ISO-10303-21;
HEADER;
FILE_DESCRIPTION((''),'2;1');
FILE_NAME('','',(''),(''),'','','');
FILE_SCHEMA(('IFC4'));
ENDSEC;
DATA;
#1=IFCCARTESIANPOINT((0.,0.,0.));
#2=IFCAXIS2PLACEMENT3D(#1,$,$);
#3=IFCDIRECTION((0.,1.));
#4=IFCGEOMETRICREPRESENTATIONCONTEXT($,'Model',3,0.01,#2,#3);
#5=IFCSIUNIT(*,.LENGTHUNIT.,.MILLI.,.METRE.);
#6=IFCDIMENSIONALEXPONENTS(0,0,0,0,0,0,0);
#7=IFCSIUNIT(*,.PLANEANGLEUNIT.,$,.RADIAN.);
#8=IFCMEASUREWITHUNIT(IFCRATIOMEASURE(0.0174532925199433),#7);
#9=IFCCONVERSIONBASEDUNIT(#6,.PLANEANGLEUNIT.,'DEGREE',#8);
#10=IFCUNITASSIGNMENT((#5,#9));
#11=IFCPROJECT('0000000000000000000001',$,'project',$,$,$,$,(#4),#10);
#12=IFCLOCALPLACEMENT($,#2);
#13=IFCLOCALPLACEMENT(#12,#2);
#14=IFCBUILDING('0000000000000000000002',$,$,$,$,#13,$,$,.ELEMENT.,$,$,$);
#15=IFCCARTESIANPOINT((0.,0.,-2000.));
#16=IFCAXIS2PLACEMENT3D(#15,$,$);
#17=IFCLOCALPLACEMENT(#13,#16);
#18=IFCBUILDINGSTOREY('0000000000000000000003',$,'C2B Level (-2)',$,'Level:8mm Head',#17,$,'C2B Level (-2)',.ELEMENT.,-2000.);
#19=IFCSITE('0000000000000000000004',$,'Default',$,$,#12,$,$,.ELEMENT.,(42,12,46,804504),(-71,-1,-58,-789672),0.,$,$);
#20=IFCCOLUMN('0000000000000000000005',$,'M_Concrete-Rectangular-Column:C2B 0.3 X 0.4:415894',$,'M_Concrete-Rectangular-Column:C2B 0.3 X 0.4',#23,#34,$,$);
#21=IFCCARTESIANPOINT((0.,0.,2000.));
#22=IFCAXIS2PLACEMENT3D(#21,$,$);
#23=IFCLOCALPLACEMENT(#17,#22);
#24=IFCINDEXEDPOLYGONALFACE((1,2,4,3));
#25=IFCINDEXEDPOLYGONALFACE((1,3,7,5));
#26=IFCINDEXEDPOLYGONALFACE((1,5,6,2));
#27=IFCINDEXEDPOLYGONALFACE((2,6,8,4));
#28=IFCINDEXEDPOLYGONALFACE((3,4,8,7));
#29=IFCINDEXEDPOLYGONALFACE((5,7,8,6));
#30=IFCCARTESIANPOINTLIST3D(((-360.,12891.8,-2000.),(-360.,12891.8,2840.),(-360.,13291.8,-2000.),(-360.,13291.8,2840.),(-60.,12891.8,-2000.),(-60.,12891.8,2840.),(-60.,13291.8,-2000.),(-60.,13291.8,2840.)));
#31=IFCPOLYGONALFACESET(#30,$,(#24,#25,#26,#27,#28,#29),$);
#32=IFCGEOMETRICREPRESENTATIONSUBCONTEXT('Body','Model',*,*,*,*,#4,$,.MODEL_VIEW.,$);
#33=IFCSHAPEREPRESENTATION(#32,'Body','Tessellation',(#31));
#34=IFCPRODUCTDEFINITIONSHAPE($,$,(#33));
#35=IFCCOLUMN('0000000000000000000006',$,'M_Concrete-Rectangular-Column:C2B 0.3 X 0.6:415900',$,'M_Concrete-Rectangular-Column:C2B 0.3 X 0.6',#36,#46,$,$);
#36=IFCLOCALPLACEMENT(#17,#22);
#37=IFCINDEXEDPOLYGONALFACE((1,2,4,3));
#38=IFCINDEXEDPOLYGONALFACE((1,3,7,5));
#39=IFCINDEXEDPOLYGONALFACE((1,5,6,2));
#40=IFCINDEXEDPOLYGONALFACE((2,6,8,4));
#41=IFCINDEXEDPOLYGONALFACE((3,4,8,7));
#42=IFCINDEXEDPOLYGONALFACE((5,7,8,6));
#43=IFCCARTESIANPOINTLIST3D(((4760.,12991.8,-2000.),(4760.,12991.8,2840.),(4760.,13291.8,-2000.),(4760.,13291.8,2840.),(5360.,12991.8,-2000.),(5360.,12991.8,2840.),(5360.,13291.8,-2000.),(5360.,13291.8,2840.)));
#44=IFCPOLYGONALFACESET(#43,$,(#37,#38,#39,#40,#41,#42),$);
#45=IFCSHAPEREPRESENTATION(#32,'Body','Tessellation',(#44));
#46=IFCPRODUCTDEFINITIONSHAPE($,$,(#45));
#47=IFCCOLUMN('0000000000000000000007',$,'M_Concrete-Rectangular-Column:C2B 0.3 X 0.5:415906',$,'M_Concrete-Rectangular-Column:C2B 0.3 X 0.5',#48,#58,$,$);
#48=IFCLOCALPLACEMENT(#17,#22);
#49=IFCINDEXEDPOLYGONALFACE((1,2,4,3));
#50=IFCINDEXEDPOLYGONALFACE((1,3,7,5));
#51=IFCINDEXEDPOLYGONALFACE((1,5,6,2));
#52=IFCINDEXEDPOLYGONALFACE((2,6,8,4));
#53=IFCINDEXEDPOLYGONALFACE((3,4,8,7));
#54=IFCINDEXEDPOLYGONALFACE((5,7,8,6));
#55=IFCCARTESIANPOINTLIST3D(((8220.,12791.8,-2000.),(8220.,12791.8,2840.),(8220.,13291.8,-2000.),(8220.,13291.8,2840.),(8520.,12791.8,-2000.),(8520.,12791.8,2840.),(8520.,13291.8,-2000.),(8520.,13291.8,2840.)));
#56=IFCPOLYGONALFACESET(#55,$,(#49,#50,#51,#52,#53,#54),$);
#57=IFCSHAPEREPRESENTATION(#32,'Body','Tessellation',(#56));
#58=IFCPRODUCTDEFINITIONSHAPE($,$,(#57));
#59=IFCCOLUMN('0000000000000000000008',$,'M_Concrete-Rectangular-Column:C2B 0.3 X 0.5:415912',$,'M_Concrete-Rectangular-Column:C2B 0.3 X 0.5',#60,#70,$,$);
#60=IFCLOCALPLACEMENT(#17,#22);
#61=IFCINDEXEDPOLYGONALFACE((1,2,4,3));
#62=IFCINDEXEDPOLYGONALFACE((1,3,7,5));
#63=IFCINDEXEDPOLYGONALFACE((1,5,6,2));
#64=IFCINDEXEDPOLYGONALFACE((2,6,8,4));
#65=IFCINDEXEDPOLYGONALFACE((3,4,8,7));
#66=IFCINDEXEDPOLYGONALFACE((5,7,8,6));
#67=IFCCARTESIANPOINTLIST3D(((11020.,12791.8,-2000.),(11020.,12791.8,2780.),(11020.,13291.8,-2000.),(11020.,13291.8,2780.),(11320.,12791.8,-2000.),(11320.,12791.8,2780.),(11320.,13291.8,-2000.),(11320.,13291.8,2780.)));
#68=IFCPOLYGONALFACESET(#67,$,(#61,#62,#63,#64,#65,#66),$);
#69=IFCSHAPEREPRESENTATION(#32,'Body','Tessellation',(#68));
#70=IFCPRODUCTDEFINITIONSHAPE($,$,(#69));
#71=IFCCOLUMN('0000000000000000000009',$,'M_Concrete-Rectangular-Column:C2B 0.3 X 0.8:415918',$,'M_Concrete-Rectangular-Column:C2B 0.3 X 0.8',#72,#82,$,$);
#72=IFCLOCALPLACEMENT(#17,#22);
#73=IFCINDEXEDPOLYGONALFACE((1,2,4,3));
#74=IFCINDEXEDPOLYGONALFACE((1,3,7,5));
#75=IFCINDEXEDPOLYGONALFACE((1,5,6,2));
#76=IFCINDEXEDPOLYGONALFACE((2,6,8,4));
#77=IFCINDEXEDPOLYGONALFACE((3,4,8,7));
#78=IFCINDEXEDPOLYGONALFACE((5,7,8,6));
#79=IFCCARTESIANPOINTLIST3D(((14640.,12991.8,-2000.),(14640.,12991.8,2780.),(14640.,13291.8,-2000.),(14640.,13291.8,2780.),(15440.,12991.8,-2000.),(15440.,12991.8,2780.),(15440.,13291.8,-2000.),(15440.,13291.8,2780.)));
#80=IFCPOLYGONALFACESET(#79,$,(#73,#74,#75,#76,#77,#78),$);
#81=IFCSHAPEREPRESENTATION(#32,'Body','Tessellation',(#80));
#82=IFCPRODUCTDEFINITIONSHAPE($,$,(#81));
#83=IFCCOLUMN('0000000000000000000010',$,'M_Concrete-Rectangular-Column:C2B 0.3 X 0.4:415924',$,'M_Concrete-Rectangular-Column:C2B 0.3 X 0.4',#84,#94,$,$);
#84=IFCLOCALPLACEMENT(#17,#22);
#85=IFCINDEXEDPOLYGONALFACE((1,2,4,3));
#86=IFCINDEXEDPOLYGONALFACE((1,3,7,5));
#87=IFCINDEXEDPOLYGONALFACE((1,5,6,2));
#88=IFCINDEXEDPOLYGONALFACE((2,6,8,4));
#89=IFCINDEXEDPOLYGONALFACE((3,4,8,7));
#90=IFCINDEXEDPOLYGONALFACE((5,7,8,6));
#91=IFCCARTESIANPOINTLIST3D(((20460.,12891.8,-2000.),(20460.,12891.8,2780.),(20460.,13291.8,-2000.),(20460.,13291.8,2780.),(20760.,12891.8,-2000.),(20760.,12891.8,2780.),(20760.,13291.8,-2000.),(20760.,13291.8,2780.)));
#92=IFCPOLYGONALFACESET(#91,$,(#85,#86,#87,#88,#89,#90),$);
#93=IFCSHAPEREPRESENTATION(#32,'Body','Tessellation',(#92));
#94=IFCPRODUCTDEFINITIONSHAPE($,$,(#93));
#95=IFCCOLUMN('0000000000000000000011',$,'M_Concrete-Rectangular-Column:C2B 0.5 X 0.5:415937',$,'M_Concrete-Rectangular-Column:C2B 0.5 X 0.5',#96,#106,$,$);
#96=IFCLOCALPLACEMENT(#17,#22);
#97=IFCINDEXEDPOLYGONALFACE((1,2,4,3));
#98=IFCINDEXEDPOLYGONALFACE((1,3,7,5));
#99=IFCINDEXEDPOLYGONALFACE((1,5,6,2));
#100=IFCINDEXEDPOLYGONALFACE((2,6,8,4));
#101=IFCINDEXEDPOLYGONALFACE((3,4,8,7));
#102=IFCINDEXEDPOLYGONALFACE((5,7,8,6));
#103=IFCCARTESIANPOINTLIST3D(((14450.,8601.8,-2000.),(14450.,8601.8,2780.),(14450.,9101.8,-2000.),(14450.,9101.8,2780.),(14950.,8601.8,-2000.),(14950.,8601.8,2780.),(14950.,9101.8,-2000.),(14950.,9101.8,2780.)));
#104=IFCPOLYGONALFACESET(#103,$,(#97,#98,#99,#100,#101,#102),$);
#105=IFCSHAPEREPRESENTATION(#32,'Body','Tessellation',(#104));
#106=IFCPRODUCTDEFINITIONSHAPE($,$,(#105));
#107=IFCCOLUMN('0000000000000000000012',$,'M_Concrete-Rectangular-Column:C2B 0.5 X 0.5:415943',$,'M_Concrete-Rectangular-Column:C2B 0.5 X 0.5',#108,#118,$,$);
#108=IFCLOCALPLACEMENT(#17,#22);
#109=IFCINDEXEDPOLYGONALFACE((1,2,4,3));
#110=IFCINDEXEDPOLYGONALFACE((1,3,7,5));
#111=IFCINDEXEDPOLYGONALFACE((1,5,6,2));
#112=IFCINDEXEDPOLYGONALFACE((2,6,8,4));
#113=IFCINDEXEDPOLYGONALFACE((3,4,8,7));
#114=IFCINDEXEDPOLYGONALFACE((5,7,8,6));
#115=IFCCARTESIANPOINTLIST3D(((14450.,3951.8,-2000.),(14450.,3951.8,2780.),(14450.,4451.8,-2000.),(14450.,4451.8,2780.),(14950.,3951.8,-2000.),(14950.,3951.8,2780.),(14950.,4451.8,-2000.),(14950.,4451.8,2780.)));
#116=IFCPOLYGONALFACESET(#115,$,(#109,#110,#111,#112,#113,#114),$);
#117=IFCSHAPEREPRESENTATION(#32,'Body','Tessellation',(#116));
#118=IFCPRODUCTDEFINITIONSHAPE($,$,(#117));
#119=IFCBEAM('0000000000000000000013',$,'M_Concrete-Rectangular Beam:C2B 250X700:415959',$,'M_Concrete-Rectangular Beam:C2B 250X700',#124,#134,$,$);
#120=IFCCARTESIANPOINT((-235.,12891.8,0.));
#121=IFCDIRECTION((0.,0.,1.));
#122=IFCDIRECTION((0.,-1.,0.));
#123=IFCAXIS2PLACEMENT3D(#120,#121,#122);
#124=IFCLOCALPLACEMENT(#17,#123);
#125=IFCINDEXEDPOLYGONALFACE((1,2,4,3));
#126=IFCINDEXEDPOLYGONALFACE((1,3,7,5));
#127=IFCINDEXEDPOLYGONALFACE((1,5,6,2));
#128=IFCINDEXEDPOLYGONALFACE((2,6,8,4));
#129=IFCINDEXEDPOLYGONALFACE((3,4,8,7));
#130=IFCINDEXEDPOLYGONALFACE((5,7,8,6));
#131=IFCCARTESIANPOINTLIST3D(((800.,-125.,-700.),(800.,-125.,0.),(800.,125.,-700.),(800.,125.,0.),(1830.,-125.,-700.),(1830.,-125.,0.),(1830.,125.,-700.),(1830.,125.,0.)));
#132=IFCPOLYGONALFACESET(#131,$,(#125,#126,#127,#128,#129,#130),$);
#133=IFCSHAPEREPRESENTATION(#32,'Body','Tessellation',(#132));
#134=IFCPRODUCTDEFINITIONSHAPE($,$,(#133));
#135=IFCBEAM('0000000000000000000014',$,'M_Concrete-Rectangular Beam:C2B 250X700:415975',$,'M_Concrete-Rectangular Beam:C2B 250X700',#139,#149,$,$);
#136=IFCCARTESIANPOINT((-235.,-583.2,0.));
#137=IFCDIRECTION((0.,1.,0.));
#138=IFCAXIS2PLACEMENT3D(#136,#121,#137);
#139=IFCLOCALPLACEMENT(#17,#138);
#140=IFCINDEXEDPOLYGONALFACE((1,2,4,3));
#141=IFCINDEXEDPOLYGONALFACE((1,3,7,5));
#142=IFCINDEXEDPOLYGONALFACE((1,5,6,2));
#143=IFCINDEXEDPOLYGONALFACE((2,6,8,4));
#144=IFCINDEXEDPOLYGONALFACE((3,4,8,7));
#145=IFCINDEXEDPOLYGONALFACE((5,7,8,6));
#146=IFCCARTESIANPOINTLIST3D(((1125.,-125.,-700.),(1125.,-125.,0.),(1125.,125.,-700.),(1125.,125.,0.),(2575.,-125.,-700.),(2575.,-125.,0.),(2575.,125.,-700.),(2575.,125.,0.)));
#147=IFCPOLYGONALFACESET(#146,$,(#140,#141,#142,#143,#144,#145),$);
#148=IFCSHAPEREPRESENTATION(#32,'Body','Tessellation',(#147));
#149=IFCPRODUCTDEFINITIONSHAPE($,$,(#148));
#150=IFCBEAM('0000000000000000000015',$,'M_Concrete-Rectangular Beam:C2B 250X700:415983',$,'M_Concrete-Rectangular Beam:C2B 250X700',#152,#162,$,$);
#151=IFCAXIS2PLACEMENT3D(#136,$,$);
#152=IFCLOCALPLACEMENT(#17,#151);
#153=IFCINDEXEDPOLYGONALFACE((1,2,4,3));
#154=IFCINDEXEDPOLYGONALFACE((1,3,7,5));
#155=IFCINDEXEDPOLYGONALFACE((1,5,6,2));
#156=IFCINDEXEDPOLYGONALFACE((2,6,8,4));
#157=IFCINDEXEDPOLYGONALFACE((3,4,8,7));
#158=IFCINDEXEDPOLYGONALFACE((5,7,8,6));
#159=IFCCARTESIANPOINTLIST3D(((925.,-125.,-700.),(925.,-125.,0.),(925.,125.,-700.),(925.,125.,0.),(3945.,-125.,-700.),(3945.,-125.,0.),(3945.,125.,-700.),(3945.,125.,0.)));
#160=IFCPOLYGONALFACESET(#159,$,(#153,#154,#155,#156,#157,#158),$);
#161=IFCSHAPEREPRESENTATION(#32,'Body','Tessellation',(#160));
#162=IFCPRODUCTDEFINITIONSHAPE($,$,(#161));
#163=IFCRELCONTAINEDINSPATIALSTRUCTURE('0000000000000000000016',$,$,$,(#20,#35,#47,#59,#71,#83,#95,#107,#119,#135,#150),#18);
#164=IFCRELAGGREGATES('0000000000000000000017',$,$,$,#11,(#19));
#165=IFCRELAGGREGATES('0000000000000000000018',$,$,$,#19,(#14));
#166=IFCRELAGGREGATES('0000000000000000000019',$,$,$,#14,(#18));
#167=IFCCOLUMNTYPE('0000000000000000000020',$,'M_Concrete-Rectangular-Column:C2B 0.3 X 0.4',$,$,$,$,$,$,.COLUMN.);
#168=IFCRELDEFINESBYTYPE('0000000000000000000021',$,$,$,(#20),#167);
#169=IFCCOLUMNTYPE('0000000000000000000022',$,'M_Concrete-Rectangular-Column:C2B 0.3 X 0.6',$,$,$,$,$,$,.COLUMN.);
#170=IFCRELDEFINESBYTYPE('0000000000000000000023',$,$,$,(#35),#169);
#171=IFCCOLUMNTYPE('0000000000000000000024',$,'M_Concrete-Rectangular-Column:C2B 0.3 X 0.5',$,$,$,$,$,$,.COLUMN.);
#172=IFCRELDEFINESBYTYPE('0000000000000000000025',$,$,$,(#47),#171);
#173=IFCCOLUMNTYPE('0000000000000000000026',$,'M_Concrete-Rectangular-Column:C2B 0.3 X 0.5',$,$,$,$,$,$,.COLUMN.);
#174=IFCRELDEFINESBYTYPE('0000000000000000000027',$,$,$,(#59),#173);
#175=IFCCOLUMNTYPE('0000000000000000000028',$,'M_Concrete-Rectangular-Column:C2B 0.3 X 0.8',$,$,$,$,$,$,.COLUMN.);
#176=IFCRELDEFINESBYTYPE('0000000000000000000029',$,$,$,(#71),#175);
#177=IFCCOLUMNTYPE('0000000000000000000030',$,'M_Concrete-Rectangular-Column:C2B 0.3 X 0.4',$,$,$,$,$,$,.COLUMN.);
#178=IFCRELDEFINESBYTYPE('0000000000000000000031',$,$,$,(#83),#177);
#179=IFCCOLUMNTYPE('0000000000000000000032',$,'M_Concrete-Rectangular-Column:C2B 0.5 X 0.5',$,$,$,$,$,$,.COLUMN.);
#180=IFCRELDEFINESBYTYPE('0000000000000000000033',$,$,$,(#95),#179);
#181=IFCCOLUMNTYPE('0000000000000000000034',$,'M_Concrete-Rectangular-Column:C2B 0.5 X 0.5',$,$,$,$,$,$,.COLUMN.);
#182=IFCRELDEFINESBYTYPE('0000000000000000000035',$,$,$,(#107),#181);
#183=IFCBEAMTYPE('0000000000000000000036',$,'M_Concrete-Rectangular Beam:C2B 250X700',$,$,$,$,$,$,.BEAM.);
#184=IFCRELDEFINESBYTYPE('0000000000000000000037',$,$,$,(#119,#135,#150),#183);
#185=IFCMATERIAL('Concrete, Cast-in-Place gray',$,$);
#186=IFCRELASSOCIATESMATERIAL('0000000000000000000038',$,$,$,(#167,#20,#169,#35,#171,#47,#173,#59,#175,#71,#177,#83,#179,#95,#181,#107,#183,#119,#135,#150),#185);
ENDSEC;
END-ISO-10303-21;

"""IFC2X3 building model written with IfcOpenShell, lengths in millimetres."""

from ifc_helpers import new_model, entity, si_unit, converted_unit, direction, frame, frame_2d, origin, origin_2d_with_axis, place, context, subcontext, project, spatial, rectangle, extrude, source, transform, mapped, material, type_object, type_shapes, element, save


model = new_model("IFC2X3")

# Units and contexts
model_context = context("Model", 3, precision=0.01, world=origin(), true_north=direction((0.0, 1.0)))
body_context = subcontext(model_context, "Body", "Model", "MODEL_VIEW")
ifc_project = project(units=[si_unit("LENGTHUNIT", "METRE", prefix="MILLI"), converted_unit("PLANEANGLEUNIT", "DEGREE", entity("IfcRatioMeasure", 0.0174532925199433), si_unit("PLANEANGLEUNIT", "RADIAN"), dimensions=[0, 0, 0, 0, 0, 0, 0])], contexts=[model_context])

# Site, building, storey
site_placement = place(None, origin())
site = spatial("IfcSite", under=ifc_project, at=site_placement, Name="Default", CompositionType="ELEMENT", RefLatitude=(42, 12, 46, 804504), RefLongitude=(-71, -1, -58, -789672), RefElevation=0.0)
building_placement = place(site_placement, origin())
building = spatial("IfcBuilding", under=site, at=building_placement, CompositionType="ELEMENT")
storey_placement = place(building_placement, frame((0.0, 0.0, -2000.0)))
storey = spatial("IfcBuildingStorey", under=building, at=storey_placement, Name="C2B Level (-2)", ObjectType="Level:8mm Head", LongName="C2B Level (-2)", CompositionType="ELEMENT", Elevation=-2000.0)

# Columns
ifc_material = material(Name="Concrete, Cast-in-Place gray")
column_type_1 = type_object("IfcColumnType", Name="M_Concrete-Rectangular-Column:C2B 0.3 X 0.4", PredefinedType="COLUMN", material=ifc_material)
shared_shape_1 = source(origin(), body_context, "Body", "SweptSolid", [
    extrude(rectangle(XDim=400.0, YDim=300.0, at=frame_2d((0.0, 0.0), x_axis=(1.0, 0.0))), frame((-210.0, 13091.8, -2000.0), z_axis=(0.0, 0.0, 1.0), x_axis=(0.0, -1.0, 0.0)), (0.0, 0.0, 1.0), 4840.0),
])
type_shapes(column_type_1, [shared_shape_1])
column_1_placement = place(storey_placement, frame((0.0, 0.0, 2000.0)))
element("IfcColumn", 1, at=column_1_placement, inside=storey, type_object=column_type_1, material=ifc_material, Name="M_Concrete-Rectangular-Column:C2B 0.3 X 0.4:415894", ObjectType="M_Concrete-Rectangular-Column:C2B 0.3 X 0.4", context=body_context, shape_type="MappedRepresentation", body=[
    mapped(shared_shape_1, transform((0.0, 0.0, 0.0), scale=1.0)),
])
column_type_2 = type_object("IfcColumnType", Name="M_Concrete-Rectangular-Column:C2B 0.3 X 0.6", PredefinedType="COLUMN", material=ifc_material)
shared_shape_2 = source(origin(), body_context, "Body", "SweptSolid", [
    extrude(rectangle(XDim=300.0, YDim=600.0, at=origin_2d_with_axis()), frame((5060.0, 13141.8, -2000.0), z_axis=(0.0, 0.0, 1.0), x_axis=(0.0, -1.0, 0.0)), (0.0, 0.0, 1.0), 4840.0),
])
type_shapes(column_type_2, [shared_shape_2])
column_2_placement = place(storey_placement, frame((0.0, 0.0, 2000.0)))
element("IfcColumn", 2, at=column_2_placement, inside=storey, type_object=column_type_2, material=ifc_material, Name="M_Concrete-Rectangular-Column:C2B 0.3 X 0.6:415900", ObjectType="M_Concrete-Rectangular-Column:C2B 0.3 X 0.6", context=body_context, shape_type="MappedRepresentation", body=[
    mapped(shared_shape_2, transform((0.0, 0.0, 0.0), scale=1.0)),
])
column_type_3 = type_object("IfcColumnType", Name="M_Concrete-Rectangular-Column:C2B 0.3 X 0.5", PredefinedType="COLUMN", material=ifc_material)
shared_shape_3 = source(origin(), body_context, "Body", "SweptSolid", [
    extrude(rectangle(XDim=500.0, YDim=300.0, at=frame_2d((0.0, 0.0), x_axis=(1.0, 0.0))), frame((8370.0, 13041.8, -2000.0), z_axis=(0.0, 0.0, 1.0), x_axis=(0.0, -1.0, 0.0)), (0.0, 0.0, 1.0), 4840.0),
])
type_shapes(column_type_3, [shared_shape_3])
column_3_placement = place(storey_placement, frame((0.0, 0.0, 2000.0)))
element("IfcColumn", 3, at=column_3_placement, inside=storey, type_object=column_type_3, material=ifc_material, Name="M_Concrete-Rectangular-Column:C2B 0.3 X 0.5:415906", ObjectType="M_Concrete-Rectangular-Column:C2B 0.3 X 0.5", context=body_context, shape_type="MappedRepresentation", body=[
    mapped(shared_shape_3, transform((0.0, 0.0, 0.0), scale=1.0)),
])
column_type_4 = type_object("IfcColumnType", Name="M_Concrete-Rectangular-Column:C2B 0.3 X 0.5", PredefinedType="COLUMN", material=ifc_material)
shared_shape_4 = source(origin(), body_context, "Body", "SweptSolid", [
    extrude(rectangle(XDim=500.0, YDim=300.0, at=origin_2d_with_axis()), frame((11170.0, 13041.8, -2000.0), z_axis=(0.0, 0.0, 1.0), x_axis=(0.0, -1.0, 0.0)), (0.0, 0.0, 1.0), 4780.0),
])
type_shapes(column_type_4, [shared_shape_4])
column_4_placement = place(storey_placement, frame((0.0, 0.0, 2000.0)))
element("IfcColumn", 4, at=column_4_placement, inside=storey, type_object=column_type_4, material=ifc_material, Name="M_Concrete-Rectangular-Column:C2B 0.3 X 0.5:415912", ObjectType="M_Concrete-Rectangular-Column:C2B 0.3 X 0.5", context=body_context, shape_type="MappedRepresentation", body=[
    mapped(shared_shape_4, transform((0.0, 0.0, 0.0), scale=1.0)),
])
column_type_5 = type_object("IfcColumnType", Name="M_Concrete-Rectangular-Column:C2B 0.3 X 0.8", PredefinedType="COLUMN", material=ifc_material)
shared_shape_5 = source(origin(), body_context, "Body", "SweptSolid", [
    extrude(rectangle(XDim=300.0, YDim=800.0, at=origin_2d_with_axis()), frame((15040.0, 13141.8, -2000.0), z_axis=(0.0, 0.0, 1.0), x_axis=(0.0, -1.0, 0.0)), (0.0, 0.0, 1.0), 4780.0),
])
type_shapes(column_type_5, [shared_shape_5])
column_5_placement = place(storey_placement, frame((0.0, 0.0, 2000.0)))
element("IfcColumn", 5, at=column_5_placement, inside=storey, type_object=column_type_5, material=ifc_material, Name="M_Concrete-Rectangular-Column:C2B 0.3 X 0.8:415918", ObjectType="M_Concrete-Rectangular-Column:C2B 0.3 X 0.8", context=body_context, shape_type="MappedRepresentation", body=[
    mapped(shared_shape_5, transform((0.0, 0.0, 0.0), scale=1.0)),
])
column_type_6 = type_object("IfcColumnType", Name="M_Concrete-Rectangular-Column:C2B 0.3 X 0.4", PredefinedType="COLUMN", material=ifc_material)
shared_shape_6 = source(origin(), body_context, "Body", "SweptSolid", [
    extrude(rectangle(XDim=400.0, YDim=300.0, at=origin_2d_with_axis()), frame((20610.0, 13091.8, -2000.0), z_axis=(0.0, 0.0, 1.0), x_axis=(0.0, -1.0, 0.0)), (0.0, 0.0, 1.0), 4780.0),
])
type_shapes(column_type_6, [shared_shape_6])
column_6_placement = place(storey_placement, frame((0.0, 0.0, 2000.0)))
element("IfcColumn", 6, at=column_6_placement, inside=storey, type_object=column_type_6, material=ifc_material, Name="M_Concrete-Rectangular-Column:C2B 0.3 X 0.4:415924", ObjectType="M_Concrete-Rectangular-Column:C2B 0.3 X 0.4", context=body_context, shape_type="MappedRepresentation", body=[
    mapped(shared_shape_6, transform((0.0, 0.0, 0.0), scale=1.0)),
])
column_type_7 = type_object("IfcColumnType", Name="M_Concrete-Rectangular-Column:C2B 0.5 X 0.5", PredefinedType="COLUMN", material=ifc_material)
shared_shape_7 = source(origin(), body_context, "Body", "SweptSolid", [
    extrude(rectangle(XDim=500.0, YDim=500.0, at=frame_2d((0.0, 0.0), x_axis=(1.0, 0.0))), frame((14700.0, 8851.8, -2000.0), z_axis=(0.0, 0.0, 1.0), x_axis=(0.0, -1.0, 0.0)), (0.0, 0.0, 1.0), 4780.0),
])
type_shapes(column_type_7, [shared_shape_7])
column_7_placement = place(storey_placement, frame((0.0, 0.0, 2000.0)))
element("IfcColumn", 7, at=column_7_placement, inside=storey, type_object=column_type_7, material=ifc_material, Name="M_Concrete-Rectangular-Column:C2B 0.5 X 0.5:415937", ObjectType="M_Concrete-Rectangular-Column:C2B 0.5 X 0.5", context=body_context, shape_type="MappedRepresentation", body=[
    mapped(shared_shape_7, transform((0.0, 0.0, 0.0), scale=1.0)),
])
column_type_8 = type_object("IfcColumnType", Name="M_Concrete-Rectangular-Column:C2B 0.5 X 0.5", PredefinedType="COLUMN", material=ifc_material)
shared_shape_8 = source(origin(), body_context, "Body", "SweptSolid", [
    extrude(rectangle(XDim=500.0, YDim=500.0, at=frame_2d((0.0, 0.0), x_axis=(1.0, 0.0))), frame((14700.0, 4201.8, -2000.0), z_axis=(0.0, 0.0, 1.0), x_axis=(0.0, -1.0, 0.0)), (0.0, 0.0, 1.0), 4780.0),
])
type_shapes(column_type_8, [shared_shape_8])
column_8_placement = place(storey_placement, frame((0.0, 0.0, 2000.0)))
element("IfcColumn", 8, at=column_8_placement, inside=storey, type_object=column_type_8, material=ifc_material, Name="M_Concrete-Rectangular-Column:C2B 0.5 X 0.5:415943", ObjectType="M_Concrete-Rectangular-Column:C2B 0.5 X 0.5", context=body_context, shape_type="MappedRepresentation", body=[
    mapped(shared_shape_8, transform((0.0, 0.0, 0.0), scale=1.0)),
])

# Beams
beam_type_1 = type_object("IfcBeamType", Name="M_Concrete-Rectangular Beam:C2B 250X700", PredefinedType="BEAM", material=ifc_material)
beam_1_placement = place(storey_placement, frame((-235.0, 12891.8, 0.0), z_axis=(0.0, 0.0, 1.0), x_axis=(0.0, -1.0, 0.0)))
element("IfcBeam", 9, at=beam_1_placement, inside=storey, type_object=beam_type_1, material=ifc_material, Name="M_Concrete-Rectangular Beam:C2B 250X700:415959", ObjectType="M_Concrete-Rectangular Beam:C2B 250X700", context=body_context, shape_type="SweptSolid", body=[
    extrude(rectangle(XDim=700.0, YDim=250.0, at=frame_2d((0.0, 0.0), x_axis=(1.0, 0.0))), frame((800.0, 0.0, -350.0), z_axis=(1.0, 0.0, 0.0), x_axis=(0.0, 0.0, -1.0)), (0.0, 0.0, 1.0), 1030.0),
])
beam_2_placement = place(storey_placement, frame((-235.0, -583.2, 0.0), z_axis=(0.0, 0.0, 1.0), x_axis=(0.0, 1.0, 0.0)))
element("IfcBeam", 10, at=beam_2_placement, inside=storey, type_object=beam_type_1, material=ifc_material, Name="M_Concrete-Rectangular Beam:C2B 250X700:415975", ObjectType="M_Concrete-Rectangular Beam:C2B 250X700", context=body_context, shape_type="SweptSolid", body=[
    extrude(rectangle(XDim=700.0, YDim=250.0, at=frame_2d((0.0, 0.0), x_axis=(1.0, 0.0))), frame((1125.0, 0.0, -350.0), z_axis=(1.0, 0.0, 0.0), x_axis=(0.0, 0.0, -1.0)), (0.0, 0.0, 1.0), 1450.0),
])
beam_3_placement = place(storey_placement, frame((-235.0, -583.2, 0.0)))
element("IfcBeam", 11, at=beam_3_placement, inside=storey, type_object=beam_type_1, material=ifc_material, Name="M_Concrete-Rectangular Beam:C2B 250X700:415983", ObjectType="M_Concrete-Rectangular Beam:C2B 250X700", context=body_context, shape_type="SweptSolid", body=[
    extrude(rectangle(XDim=700.0, YDim=250.0, at=frame_2d((0.0, 0.0), x_axis=(1.0, 0.0))), frame((925.0, 0.0, -350.0), z_axis=(1.0, 0.0, 0.0), x_axis=(0.0, 0.0, -1.0)), (0.0, 0.0, 1.0), 3020.0),
])

save(model, "model.ifc")
